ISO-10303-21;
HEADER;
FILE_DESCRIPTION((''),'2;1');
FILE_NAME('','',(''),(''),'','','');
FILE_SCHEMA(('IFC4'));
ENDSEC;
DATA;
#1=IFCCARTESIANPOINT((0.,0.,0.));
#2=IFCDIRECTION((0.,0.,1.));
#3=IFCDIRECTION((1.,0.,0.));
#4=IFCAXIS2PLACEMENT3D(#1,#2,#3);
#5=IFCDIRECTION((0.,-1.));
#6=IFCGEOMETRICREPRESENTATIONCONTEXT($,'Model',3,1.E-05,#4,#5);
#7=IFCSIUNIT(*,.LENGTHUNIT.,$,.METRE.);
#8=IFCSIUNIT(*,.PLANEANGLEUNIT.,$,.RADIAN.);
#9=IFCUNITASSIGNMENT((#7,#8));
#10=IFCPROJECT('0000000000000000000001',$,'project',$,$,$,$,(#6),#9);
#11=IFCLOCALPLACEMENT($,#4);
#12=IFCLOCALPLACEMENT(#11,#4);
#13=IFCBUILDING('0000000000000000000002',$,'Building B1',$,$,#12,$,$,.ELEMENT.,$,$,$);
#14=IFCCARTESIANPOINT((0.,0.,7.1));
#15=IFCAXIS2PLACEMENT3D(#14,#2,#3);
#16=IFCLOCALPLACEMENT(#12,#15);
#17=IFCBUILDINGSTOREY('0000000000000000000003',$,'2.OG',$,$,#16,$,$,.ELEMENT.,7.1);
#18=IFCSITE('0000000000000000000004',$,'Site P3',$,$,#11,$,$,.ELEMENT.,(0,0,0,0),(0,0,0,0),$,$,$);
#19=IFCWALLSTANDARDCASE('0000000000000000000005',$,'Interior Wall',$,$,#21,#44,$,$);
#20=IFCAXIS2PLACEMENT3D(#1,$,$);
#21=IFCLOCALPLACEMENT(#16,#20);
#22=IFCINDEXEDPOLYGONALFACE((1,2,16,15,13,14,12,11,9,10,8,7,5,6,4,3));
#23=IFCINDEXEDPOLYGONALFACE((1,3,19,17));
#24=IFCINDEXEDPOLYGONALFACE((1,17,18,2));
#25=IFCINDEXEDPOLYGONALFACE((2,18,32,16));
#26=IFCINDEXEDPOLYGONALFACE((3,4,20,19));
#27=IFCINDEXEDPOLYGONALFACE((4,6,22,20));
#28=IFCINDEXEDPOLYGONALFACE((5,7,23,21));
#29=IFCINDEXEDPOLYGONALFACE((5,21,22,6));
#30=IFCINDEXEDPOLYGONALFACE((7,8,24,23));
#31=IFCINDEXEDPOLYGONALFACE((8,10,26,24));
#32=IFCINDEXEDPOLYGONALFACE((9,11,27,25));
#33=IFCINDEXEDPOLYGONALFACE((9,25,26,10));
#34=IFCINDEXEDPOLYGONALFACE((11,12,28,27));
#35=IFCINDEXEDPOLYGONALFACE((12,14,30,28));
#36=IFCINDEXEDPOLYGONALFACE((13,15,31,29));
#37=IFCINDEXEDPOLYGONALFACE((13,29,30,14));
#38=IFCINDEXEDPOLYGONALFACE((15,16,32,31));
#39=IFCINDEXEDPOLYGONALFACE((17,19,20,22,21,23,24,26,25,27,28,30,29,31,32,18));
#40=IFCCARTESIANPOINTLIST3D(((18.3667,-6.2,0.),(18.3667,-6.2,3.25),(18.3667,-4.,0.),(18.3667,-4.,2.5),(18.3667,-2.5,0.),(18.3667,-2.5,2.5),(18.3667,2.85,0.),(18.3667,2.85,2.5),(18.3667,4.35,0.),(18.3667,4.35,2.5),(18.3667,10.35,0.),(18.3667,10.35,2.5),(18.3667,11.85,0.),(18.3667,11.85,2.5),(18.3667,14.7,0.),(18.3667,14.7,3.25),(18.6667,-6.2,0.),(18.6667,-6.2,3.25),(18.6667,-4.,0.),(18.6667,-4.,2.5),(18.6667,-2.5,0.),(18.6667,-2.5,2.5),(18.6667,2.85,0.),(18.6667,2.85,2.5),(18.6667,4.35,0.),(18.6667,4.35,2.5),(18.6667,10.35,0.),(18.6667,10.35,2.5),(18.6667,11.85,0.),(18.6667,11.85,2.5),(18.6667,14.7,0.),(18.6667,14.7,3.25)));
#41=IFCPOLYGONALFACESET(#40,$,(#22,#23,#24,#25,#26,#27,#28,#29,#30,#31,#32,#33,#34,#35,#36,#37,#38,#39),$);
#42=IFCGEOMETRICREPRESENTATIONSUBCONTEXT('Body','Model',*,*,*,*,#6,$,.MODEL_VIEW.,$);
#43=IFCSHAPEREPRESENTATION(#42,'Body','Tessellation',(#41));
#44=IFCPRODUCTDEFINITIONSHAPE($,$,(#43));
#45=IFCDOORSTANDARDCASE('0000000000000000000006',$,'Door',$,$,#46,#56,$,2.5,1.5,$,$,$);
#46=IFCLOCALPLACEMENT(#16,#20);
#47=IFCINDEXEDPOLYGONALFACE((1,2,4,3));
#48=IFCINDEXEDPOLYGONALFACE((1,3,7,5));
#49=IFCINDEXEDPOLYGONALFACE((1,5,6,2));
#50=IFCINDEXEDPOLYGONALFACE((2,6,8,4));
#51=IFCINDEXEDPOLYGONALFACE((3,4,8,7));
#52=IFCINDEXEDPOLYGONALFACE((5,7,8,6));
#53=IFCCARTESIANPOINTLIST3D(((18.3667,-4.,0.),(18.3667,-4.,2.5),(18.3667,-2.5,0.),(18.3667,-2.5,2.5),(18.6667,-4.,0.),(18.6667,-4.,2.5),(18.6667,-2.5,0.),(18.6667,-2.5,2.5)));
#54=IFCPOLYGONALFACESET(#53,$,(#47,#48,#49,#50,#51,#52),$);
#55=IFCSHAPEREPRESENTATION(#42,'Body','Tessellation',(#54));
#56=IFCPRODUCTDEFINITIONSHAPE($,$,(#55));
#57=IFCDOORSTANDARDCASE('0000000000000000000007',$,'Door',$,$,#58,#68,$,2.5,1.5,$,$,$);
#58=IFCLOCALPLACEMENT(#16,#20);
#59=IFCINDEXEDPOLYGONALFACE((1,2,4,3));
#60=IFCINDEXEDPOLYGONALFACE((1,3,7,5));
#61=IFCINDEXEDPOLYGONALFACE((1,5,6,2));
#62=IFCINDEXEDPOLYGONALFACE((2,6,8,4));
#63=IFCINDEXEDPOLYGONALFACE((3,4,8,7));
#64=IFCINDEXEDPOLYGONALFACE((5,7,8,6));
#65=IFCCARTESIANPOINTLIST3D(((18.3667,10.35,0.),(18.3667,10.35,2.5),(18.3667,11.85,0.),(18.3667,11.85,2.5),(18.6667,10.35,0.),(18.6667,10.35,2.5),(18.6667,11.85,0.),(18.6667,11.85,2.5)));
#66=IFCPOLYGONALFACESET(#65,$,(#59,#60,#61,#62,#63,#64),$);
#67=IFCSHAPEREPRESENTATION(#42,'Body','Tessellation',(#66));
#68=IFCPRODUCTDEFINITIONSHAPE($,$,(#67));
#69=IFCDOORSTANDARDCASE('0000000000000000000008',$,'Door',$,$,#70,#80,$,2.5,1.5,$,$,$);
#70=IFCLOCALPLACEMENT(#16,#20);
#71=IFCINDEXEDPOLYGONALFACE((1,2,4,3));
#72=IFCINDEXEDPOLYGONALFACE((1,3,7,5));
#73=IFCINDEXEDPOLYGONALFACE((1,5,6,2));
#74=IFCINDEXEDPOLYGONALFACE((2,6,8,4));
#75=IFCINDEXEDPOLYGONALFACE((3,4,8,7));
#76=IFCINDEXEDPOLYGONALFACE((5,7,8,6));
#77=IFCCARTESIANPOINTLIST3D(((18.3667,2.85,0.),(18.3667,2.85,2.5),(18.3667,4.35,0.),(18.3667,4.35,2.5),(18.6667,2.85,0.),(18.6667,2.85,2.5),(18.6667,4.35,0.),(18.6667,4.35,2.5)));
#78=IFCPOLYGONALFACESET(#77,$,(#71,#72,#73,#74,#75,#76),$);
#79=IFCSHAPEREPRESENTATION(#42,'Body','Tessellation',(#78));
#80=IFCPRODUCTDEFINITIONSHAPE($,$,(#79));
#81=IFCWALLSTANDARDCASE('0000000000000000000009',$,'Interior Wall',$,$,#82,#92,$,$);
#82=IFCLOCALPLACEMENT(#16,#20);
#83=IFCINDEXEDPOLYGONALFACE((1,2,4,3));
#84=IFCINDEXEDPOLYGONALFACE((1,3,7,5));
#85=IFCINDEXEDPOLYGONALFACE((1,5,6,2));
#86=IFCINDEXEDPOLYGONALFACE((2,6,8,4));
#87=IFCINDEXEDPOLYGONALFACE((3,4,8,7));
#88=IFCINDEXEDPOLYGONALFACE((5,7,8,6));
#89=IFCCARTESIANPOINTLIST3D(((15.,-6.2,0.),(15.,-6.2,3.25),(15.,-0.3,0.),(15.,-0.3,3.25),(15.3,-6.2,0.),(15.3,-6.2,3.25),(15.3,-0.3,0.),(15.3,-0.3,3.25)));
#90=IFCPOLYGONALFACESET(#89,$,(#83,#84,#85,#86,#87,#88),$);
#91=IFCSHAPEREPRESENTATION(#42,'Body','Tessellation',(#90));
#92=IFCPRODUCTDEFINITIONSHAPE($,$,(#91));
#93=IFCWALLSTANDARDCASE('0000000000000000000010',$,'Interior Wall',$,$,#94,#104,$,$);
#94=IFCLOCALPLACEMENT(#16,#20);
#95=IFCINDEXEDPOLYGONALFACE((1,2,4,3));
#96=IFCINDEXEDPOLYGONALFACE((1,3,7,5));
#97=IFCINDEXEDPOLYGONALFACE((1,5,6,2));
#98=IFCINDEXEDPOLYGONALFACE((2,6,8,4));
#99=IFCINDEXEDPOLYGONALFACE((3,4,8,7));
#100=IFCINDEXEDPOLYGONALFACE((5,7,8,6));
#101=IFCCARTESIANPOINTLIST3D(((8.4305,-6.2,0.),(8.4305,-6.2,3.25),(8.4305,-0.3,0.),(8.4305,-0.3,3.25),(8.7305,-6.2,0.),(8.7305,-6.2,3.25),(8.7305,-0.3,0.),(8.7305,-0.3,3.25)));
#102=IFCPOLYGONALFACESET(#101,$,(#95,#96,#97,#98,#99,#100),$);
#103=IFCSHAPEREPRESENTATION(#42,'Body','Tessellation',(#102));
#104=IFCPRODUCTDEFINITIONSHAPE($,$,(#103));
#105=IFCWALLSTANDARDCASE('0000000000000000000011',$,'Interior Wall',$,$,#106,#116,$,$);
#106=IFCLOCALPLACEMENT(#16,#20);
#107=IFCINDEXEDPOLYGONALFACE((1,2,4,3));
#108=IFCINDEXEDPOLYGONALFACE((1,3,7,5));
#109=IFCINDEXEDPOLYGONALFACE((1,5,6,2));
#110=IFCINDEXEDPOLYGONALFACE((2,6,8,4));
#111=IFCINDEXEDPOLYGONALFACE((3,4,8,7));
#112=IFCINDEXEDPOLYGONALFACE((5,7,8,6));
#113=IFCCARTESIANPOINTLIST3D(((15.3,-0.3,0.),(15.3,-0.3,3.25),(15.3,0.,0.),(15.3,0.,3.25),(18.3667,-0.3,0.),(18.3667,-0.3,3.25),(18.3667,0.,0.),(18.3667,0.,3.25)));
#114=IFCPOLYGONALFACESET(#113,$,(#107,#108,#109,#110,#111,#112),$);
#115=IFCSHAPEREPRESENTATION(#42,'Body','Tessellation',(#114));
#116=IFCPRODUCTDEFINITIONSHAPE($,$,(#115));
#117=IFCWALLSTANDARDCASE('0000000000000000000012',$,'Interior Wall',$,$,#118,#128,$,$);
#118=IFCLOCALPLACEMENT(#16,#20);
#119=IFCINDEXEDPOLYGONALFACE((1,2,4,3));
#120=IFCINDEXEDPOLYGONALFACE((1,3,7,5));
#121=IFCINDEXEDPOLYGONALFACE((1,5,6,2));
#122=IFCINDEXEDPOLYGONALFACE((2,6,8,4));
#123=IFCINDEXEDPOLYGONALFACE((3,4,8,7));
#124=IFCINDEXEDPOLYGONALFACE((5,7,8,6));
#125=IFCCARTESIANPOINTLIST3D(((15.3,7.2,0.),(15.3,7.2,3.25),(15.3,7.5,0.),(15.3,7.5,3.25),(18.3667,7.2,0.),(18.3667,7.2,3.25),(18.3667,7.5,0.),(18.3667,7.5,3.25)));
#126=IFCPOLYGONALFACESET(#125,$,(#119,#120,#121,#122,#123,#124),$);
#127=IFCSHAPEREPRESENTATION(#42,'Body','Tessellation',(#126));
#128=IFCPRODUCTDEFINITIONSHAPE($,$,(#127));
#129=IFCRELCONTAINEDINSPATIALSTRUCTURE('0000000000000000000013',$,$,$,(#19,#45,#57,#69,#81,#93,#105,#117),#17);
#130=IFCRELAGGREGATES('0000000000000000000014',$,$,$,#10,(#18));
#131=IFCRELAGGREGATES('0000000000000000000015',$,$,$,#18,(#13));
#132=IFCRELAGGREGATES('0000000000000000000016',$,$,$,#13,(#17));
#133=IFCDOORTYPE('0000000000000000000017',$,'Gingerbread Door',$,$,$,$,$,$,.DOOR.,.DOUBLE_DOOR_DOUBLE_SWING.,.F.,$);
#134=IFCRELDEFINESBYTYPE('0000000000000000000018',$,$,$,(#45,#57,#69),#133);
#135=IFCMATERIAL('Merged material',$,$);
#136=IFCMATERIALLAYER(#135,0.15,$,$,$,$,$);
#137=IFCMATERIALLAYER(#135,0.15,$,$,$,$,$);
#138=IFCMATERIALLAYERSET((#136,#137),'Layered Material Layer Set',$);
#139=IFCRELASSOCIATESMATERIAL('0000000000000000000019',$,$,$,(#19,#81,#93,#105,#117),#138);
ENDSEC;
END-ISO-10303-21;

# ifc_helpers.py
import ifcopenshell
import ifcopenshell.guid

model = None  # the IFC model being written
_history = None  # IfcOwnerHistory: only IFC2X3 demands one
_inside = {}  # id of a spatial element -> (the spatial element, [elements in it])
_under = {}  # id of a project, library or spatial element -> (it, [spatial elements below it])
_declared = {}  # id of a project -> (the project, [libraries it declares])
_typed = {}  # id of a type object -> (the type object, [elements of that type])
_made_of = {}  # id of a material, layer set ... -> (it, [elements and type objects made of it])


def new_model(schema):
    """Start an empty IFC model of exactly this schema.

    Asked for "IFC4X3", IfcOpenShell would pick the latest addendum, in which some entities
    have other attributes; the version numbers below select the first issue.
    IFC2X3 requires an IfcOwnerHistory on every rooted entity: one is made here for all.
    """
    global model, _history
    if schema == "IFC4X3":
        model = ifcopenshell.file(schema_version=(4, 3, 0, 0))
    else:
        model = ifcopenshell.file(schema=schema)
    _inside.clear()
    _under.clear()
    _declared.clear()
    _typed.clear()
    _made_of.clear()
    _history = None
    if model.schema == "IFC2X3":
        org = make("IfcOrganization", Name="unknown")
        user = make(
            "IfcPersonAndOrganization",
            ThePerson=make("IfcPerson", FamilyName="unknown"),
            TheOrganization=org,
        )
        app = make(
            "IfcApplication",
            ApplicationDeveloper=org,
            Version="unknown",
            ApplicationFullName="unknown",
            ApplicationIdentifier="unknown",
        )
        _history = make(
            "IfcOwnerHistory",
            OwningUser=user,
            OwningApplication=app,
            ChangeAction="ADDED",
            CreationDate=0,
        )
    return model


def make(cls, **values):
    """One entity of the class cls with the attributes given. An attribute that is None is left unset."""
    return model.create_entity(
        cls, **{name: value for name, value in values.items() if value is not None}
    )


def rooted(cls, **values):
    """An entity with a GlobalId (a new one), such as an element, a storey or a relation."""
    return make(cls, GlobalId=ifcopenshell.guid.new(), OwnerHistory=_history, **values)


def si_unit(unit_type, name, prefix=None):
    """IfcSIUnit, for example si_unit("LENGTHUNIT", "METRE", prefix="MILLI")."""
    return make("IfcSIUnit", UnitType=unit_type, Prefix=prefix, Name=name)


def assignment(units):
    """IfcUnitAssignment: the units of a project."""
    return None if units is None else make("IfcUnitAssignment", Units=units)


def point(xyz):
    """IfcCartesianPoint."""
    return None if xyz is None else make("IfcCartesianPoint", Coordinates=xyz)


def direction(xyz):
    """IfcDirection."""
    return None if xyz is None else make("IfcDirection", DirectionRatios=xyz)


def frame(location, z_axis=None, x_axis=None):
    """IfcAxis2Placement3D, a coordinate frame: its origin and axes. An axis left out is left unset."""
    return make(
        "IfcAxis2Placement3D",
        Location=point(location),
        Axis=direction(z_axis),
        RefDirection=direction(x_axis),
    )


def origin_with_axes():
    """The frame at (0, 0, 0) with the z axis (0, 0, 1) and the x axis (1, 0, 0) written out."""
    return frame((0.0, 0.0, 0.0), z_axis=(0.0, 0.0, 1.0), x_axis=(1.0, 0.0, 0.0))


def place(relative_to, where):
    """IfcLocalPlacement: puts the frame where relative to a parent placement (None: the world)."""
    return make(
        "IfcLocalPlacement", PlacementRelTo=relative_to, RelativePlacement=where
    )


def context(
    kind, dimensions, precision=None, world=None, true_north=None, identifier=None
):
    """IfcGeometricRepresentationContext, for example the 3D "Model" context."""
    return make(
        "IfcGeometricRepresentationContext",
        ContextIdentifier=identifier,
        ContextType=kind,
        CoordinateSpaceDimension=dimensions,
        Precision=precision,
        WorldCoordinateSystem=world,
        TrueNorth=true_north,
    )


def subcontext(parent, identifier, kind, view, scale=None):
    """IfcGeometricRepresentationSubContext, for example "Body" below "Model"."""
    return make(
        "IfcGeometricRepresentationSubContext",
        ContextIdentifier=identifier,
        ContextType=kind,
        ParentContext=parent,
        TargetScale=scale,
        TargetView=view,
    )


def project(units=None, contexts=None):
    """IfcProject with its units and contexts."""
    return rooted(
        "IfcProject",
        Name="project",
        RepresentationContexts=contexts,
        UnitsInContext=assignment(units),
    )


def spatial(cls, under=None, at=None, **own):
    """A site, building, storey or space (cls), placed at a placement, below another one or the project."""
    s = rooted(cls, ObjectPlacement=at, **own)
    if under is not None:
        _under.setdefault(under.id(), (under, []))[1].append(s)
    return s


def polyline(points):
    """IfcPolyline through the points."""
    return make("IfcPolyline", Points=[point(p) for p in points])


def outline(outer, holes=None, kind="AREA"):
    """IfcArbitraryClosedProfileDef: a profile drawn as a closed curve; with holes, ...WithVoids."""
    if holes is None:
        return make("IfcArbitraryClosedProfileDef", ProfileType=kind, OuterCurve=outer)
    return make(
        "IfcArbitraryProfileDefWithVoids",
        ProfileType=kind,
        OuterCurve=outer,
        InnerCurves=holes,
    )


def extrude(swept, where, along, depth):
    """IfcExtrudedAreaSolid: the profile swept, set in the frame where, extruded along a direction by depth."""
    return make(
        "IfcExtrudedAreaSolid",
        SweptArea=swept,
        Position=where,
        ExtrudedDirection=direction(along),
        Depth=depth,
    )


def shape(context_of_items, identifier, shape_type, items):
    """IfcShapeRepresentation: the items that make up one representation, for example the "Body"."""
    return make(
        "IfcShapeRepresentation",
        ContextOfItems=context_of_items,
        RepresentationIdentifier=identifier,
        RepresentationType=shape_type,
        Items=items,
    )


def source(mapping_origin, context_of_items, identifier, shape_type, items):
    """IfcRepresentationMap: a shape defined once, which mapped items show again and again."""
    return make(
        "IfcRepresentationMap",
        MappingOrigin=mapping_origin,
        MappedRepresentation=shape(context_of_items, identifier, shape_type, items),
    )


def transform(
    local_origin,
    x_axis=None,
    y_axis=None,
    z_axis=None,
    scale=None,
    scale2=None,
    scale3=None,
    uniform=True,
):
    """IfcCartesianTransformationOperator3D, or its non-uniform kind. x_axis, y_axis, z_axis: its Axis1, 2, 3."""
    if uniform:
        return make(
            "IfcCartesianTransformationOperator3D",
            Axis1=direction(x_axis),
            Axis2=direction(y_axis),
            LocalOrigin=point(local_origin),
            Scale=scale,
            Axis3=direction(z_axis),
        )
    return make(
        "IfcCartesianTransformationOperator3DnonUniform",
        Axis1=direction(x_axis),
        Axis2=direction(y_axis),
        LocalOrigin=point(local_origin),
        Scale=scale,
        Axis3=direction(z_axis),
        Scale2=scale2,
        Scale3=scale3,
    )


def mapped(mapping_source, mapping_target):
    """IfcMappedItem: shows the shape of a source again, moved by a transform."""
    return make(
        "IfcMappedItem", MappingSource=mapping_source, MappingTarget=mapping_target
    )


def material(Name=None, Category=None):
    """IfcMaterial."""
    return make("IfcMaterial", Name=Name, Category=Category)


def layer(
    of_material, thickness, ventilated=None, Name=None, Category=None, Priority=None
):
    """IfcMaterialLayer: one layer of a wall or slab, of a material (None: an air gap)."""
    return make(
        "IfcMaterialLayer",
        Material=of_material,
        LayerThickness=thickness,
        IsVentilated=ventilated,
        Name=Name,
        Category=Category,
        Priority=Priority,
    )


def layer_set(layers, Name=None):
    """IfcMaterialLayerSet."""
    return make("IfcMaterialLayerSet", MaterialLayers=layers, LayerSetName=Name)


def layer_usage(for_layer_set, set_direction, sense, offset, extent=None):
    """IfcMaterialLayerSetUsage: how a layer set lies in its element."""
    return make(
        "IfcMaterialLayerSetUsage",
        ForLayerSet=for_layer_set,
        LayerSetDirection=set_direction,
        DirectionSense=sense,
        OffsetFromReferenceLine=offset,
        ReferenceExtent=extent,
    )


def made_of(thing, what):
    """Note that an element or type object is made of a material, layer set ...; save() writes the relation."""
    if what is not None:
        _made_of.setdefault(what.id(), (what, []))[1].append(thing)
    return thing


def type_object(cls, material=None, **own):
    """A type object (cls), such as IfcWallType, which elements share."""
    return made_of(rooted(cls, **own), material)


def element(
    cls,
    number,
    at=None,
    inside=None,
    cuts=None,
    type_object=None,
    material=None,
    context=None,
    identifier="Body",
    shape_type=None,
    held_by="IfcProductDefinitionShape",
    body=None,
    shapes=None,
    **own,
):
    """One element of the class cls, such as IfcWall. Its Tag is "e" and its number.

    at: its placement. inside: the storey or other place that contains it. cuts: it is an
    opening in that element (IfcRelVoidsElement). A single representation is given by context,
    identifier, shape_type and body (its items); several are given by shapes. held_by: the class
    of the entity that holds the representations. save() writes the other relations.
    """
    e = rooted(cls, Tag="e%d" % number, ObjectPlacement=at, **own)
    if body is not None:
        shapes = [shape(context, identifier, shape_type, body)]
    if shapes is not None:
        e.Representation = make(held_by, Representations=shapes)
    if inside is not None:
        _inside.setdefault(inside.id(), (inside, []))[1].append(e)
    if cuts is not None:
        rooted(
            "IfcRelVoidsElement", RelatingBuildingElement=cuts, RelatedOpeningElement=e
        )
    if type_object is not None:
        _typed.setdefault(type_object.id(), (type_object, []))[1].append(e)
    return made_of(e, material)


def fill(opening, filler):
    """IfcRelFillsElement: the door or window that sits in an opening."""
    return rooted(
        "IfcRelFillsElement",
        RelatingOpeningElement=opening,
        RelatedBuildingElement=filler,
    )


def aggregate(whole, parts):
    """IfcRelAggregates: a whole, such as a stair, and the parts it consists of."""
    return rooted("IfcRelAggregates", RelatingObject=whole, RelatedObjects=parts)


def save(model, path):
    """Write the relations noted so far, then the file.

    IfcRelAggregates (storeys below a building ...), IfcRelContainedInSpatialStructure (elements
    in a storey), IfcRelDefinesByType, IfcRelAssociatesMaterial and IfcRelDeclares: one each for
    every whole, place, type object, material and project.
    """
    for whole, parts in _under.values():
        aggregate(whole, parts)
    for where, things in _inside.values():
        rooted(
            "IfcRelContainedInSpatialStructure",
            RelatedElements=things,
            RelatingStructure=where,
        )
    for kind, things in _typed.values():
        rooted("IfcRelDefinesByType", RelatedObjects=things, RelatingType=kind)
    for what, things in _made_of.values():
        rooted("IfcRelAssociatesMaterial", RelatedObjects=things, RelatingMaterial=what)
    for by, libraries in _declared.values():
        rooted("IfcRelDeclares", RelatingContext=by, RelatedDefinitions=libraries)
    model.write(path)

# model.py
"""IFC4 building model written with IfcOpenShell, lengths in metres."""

from ifc_helpers import new_model, si_unit, direction, frame, origin_with_axes, place, context, subcontext, project, spatial, polyline, outline, extrude, source, transform, mapped, material, layer, layer_set, layer_usage, type_object, element, fill, save


model = new_model("IFC4")

# Units and contexts
model_context = context("Model", 3, precision=1e-05, world=origin_with_axes(), true_north=direction((0.0, -1.0)))
body_context = subcontext(model_context, "Body", "Model", "MODEL_VIEW")
ifc_project = project(units=[si_unit("LENGTHUNIT", "METRE"), si_unit("PLANEANGLEUNIT", "RADIAN")], contexts=[model_context])

# Site, building, storey
site_placement = place(None, origin_with_axes())
site = spatial("IfcSite", under=ifc_project, at=site_placement, Name="Site P3", CompositionType="ELEMENT", RefLatitude=(0, 0, 0, 0), RefLongitude=(0, 0, 0, 0))
building_placement = place(site_placement, origin_with_axes())
building = spatial("IfcBuilding", under=site, at=building_placement, Name="Building B1", CompositionType="ELEMENT")
storey_placement = place(building_placement, frame((0.0, 0.0, 7.1), z_axis=(0.0, 0.0, 1.0), x_axis=(1.0, 0.0, 0.0)))
storey = spatial("IfcBuildingStorey", under=building, at=storey_placement, Name="2.OG", CompositionType="ELEMENT", Elevation=7.1)

# Shared definitions
ifc_material = material(Name="Merged material")

# Wall, openings, doors
ifc_layer_1 = layer(ifc_material, 0.15)
ifc_layer_2 = layer(ifc_material, 0.15)
ifc_layer_set_1 = layer_set([ifc_layer_1, ifc_layer_2], Name="Layered Material Layer Set")
ifc_layer_usage_1 = layer_usage(ifc_layer_set_1, "AXIS2", "POSITIVE", -0.15)
wall_1_placement = place(storey_placement, frame((18.5167, 14.7, 0.0), z_axis=(0.0, 0.0, 1.0), x_axis=(0.0, -1.0, 0.0)))
wall_1 = element("IfcWallStandardCase", 1, at=wall_1_placement, inside=storey, material=ifc_layer_usage_1, Name="Interior Wall", context=body_context, shape_type="SweptSolid", body=[
    extrude(outline(polyline([(0.0, 0.15), (20.9, 0.15), (20.9, -0.15), (0.0, -0.15), (0.0, 0.15)])), origin_with_axes(), (0.0, 0.0, 1.0), 3.25),
])
opening_1_placement = place(wall_1_placement, frame((17.2, 0.0, 0.0), z_axis=(0.0, 0.0, 1.0), x_axis=(1.0, 0.0, 0.0)))
opening_1 = element("IfcOpeningStandardCase", 2, at=opening_1_placement, cuts=wall_1, context=body_context, shape_type="SweptSolid", body=[
    extrude(outline(polyline([(0.0, 0.0), (0.0, 1.5), (2.5, 1.5), (2.5, 0.0), (0.0, 0.0)])), frame((0.0, -0.15, 0.0), z_axis=(0.0, 1.0, 0.0), x_axis=(0.0, 0.0, 1.0)), (0.0, 0.0, 1.0), 0.3),
])
opening_2_placement = place(wall_1_placement, frame((2.85, 0.0, 0.0), z_axis=(0.0, 0.0, 1.0), x_axis=(1.0, 0.0, 0.0)))
opening_2 = element("IfcOpeningStandardCase", 3, at=opening_2_placement, cuts=wall_1, context=body_context, shape_type="SweptSolid", body=[
    extrude(outline(polyline([(0.0, 0.0), (0.0, 1.5), (2.5, 1.5), (2.5, 0.0), (0.0, 0.0)])), frame((0.0, -0.15, 0.0), z_axis=(0.0, 1.0, 0.0), x_axis=(0.0, 0.0, 1.0)), (0.0, 0.0, 1.0), 0.3),
])
opening_3_placement = place(wall_1_placement, frame((10.35, 0.0, 0.0), z_axis=(0.0, 0.0, 1.0), x_axis=(1.0, 0.0, 0.0)))
opening_3 = element("IfcOpeningStandardCase", 4, at=opening_3_placement, cuts=wall_1, context=body_context, shape_type="SweptSolid", body=[
    extrude(outline(polyline([(0.0, 0.0), (0.0, 1.5), (2.5, 1.5), (2.5, 0.0), (0.0, 0.0)])), frame((0.0, -0.15, 0.0), z_axis=(0.0, 1.0, 0.0), x_axis=(0.0, 0.0, 1.0)), (0.0, 0.0, 1.0), 0.3),
])
door_type = type_object("IfcDoorType", Name="Gingerbread Door", OperationType="DOUBLE_DOOR_DOUBLE_SWING", ParameterTakesPrecedence=False, PredefinedType="DOOR")
shared_shape_1 = source(origin_with_axes(), body_context, "Body", "SweptSolid", [
    extrude(outline(polyline([(0.0, 0.0), (0.0, 1.5), (2.5, 1.5), (2.5, 0.0), (0.0, 0.0)])), frame((0.0, -0.15, 0.0), z_axis=(0.0, 1.0, 0.0), x_axis=(0.0, 0.0, 1.0)), (0.0, 0.0, 1.0), 0.3),
])
door_1_placement = place(opening_1_placement, origin_with_axes())
door_1 = element("IfcDoorStandardCase", 5, at=door_1_placement, inside=storey, type_object=door_type, Name="Door", OverallHeight=2.5, OverallWidth=1.5, context=body_context, shape_type="MappedRepresentation", body=[
    mapped(shared_shape_1, transform((0.0, 0.0, 0.0))),
])
fill(opening_1, door_1)
door_2_placement = place(opening_2_placement, origin_with_axes())
door_2 = element("IfcDoorStandardCase", 6, at=door_2_placement, inside=storey, type_object=door_type, Name="Door", OverallHeight=2.5, OverallWidth=1.5, context=body_context, shape_type="MappedRepresentation", body=[
    mapped(shared_shape_1, transform((0.0, 0.0, 0.0))),
])
fill(opening_2, door_2)
door_3_placement = place(opening_3_placement, origin_with_axes())
door_3 = element("IfcDoorStandardCase", 7, at=door_3_placement, inside=storey, type_object=door_type, Name="Door", OverallHeight=2.5, OverallWidth=1.5, context=body_context, shape_type="MappedRepresentation", body=[
    mapped(shared_shape_1, transform((0.0, 0.0, 0.0))),
])
fill(opening_3, door_3)

# Walls
for number, where, z_axis, x_axis, name in (
    (8, (15.15, -0.3, 0.0), (0.0, 0.0, 1.0), (0.0, -1.0, 0.0), "Interior Wall"),
    (9, (8.5805, -0.3, 0.0), (0.0, 0.0, 1.0), (0.0, -1.0, 0.0), "Interior Wall"),
):
    element("IfcWallStandardCase", number, at=place(storey_placement, frame(where, z_axis=z_axis, x_axis=x_axis)), inside=storey, material=ifc_layer_usage_1, Name=name, context=body_context, shape_type="SweptSolid", body=[
        extrude(outline(polyline([(0.0, 0.15), (5.9, 0.15), (5.9, -0.15), (0.0, -0.15), (0.0, 0.15)])), origin_with_axes(), (0.0, 0.0, 1.0), 3.25),
    ])
wall_2_placement = place(storey_placement, frame((15.3, -0.15, 0.0), z_axis=(0.0, 0.0, 1.0), x_axis=(1.0, 0.0, 0.0)))
element("IfcWallStandardCase", 10, at=wall_2_placement, inside=storey, material=ifc_layer_usage_1, Name="Interior Wall", context=body_context, shape_type="SweptSolid", body=[
    extrude(outline(polyline([(0.0, 0.15), (3.0667, 0.15), (3.0667, -0.15), (0.0, -0.15), (0.0, 0.15)])), origin_with_axes(), (0.0, 0.0, 1.0), 3.25),
])
wall_3_placement = place(storey_placement, frame((15.3, 7.35, 0.0), z_axis=(0.0, 0.0, 1.0), x_axis=(1.0, 0.0, 0.0)))
element("IfcWallStandardCase", 11, at=wall_3_placement, inside=storey, material=ifc_layer_usage_1, Name="Interior Wall", context=body_context, shape_type="SweptSolid", body=[
    extrude(outline(polyline([(0.0, 0.15), (3.0667, 0.15), (3.0667, -0.15), (0.0, -0.15), (0.0, 0.15)])), origin_with_axes(), (0.0, 0.0, 1.0), 3.25),
])

save(model, "model.ifc")
